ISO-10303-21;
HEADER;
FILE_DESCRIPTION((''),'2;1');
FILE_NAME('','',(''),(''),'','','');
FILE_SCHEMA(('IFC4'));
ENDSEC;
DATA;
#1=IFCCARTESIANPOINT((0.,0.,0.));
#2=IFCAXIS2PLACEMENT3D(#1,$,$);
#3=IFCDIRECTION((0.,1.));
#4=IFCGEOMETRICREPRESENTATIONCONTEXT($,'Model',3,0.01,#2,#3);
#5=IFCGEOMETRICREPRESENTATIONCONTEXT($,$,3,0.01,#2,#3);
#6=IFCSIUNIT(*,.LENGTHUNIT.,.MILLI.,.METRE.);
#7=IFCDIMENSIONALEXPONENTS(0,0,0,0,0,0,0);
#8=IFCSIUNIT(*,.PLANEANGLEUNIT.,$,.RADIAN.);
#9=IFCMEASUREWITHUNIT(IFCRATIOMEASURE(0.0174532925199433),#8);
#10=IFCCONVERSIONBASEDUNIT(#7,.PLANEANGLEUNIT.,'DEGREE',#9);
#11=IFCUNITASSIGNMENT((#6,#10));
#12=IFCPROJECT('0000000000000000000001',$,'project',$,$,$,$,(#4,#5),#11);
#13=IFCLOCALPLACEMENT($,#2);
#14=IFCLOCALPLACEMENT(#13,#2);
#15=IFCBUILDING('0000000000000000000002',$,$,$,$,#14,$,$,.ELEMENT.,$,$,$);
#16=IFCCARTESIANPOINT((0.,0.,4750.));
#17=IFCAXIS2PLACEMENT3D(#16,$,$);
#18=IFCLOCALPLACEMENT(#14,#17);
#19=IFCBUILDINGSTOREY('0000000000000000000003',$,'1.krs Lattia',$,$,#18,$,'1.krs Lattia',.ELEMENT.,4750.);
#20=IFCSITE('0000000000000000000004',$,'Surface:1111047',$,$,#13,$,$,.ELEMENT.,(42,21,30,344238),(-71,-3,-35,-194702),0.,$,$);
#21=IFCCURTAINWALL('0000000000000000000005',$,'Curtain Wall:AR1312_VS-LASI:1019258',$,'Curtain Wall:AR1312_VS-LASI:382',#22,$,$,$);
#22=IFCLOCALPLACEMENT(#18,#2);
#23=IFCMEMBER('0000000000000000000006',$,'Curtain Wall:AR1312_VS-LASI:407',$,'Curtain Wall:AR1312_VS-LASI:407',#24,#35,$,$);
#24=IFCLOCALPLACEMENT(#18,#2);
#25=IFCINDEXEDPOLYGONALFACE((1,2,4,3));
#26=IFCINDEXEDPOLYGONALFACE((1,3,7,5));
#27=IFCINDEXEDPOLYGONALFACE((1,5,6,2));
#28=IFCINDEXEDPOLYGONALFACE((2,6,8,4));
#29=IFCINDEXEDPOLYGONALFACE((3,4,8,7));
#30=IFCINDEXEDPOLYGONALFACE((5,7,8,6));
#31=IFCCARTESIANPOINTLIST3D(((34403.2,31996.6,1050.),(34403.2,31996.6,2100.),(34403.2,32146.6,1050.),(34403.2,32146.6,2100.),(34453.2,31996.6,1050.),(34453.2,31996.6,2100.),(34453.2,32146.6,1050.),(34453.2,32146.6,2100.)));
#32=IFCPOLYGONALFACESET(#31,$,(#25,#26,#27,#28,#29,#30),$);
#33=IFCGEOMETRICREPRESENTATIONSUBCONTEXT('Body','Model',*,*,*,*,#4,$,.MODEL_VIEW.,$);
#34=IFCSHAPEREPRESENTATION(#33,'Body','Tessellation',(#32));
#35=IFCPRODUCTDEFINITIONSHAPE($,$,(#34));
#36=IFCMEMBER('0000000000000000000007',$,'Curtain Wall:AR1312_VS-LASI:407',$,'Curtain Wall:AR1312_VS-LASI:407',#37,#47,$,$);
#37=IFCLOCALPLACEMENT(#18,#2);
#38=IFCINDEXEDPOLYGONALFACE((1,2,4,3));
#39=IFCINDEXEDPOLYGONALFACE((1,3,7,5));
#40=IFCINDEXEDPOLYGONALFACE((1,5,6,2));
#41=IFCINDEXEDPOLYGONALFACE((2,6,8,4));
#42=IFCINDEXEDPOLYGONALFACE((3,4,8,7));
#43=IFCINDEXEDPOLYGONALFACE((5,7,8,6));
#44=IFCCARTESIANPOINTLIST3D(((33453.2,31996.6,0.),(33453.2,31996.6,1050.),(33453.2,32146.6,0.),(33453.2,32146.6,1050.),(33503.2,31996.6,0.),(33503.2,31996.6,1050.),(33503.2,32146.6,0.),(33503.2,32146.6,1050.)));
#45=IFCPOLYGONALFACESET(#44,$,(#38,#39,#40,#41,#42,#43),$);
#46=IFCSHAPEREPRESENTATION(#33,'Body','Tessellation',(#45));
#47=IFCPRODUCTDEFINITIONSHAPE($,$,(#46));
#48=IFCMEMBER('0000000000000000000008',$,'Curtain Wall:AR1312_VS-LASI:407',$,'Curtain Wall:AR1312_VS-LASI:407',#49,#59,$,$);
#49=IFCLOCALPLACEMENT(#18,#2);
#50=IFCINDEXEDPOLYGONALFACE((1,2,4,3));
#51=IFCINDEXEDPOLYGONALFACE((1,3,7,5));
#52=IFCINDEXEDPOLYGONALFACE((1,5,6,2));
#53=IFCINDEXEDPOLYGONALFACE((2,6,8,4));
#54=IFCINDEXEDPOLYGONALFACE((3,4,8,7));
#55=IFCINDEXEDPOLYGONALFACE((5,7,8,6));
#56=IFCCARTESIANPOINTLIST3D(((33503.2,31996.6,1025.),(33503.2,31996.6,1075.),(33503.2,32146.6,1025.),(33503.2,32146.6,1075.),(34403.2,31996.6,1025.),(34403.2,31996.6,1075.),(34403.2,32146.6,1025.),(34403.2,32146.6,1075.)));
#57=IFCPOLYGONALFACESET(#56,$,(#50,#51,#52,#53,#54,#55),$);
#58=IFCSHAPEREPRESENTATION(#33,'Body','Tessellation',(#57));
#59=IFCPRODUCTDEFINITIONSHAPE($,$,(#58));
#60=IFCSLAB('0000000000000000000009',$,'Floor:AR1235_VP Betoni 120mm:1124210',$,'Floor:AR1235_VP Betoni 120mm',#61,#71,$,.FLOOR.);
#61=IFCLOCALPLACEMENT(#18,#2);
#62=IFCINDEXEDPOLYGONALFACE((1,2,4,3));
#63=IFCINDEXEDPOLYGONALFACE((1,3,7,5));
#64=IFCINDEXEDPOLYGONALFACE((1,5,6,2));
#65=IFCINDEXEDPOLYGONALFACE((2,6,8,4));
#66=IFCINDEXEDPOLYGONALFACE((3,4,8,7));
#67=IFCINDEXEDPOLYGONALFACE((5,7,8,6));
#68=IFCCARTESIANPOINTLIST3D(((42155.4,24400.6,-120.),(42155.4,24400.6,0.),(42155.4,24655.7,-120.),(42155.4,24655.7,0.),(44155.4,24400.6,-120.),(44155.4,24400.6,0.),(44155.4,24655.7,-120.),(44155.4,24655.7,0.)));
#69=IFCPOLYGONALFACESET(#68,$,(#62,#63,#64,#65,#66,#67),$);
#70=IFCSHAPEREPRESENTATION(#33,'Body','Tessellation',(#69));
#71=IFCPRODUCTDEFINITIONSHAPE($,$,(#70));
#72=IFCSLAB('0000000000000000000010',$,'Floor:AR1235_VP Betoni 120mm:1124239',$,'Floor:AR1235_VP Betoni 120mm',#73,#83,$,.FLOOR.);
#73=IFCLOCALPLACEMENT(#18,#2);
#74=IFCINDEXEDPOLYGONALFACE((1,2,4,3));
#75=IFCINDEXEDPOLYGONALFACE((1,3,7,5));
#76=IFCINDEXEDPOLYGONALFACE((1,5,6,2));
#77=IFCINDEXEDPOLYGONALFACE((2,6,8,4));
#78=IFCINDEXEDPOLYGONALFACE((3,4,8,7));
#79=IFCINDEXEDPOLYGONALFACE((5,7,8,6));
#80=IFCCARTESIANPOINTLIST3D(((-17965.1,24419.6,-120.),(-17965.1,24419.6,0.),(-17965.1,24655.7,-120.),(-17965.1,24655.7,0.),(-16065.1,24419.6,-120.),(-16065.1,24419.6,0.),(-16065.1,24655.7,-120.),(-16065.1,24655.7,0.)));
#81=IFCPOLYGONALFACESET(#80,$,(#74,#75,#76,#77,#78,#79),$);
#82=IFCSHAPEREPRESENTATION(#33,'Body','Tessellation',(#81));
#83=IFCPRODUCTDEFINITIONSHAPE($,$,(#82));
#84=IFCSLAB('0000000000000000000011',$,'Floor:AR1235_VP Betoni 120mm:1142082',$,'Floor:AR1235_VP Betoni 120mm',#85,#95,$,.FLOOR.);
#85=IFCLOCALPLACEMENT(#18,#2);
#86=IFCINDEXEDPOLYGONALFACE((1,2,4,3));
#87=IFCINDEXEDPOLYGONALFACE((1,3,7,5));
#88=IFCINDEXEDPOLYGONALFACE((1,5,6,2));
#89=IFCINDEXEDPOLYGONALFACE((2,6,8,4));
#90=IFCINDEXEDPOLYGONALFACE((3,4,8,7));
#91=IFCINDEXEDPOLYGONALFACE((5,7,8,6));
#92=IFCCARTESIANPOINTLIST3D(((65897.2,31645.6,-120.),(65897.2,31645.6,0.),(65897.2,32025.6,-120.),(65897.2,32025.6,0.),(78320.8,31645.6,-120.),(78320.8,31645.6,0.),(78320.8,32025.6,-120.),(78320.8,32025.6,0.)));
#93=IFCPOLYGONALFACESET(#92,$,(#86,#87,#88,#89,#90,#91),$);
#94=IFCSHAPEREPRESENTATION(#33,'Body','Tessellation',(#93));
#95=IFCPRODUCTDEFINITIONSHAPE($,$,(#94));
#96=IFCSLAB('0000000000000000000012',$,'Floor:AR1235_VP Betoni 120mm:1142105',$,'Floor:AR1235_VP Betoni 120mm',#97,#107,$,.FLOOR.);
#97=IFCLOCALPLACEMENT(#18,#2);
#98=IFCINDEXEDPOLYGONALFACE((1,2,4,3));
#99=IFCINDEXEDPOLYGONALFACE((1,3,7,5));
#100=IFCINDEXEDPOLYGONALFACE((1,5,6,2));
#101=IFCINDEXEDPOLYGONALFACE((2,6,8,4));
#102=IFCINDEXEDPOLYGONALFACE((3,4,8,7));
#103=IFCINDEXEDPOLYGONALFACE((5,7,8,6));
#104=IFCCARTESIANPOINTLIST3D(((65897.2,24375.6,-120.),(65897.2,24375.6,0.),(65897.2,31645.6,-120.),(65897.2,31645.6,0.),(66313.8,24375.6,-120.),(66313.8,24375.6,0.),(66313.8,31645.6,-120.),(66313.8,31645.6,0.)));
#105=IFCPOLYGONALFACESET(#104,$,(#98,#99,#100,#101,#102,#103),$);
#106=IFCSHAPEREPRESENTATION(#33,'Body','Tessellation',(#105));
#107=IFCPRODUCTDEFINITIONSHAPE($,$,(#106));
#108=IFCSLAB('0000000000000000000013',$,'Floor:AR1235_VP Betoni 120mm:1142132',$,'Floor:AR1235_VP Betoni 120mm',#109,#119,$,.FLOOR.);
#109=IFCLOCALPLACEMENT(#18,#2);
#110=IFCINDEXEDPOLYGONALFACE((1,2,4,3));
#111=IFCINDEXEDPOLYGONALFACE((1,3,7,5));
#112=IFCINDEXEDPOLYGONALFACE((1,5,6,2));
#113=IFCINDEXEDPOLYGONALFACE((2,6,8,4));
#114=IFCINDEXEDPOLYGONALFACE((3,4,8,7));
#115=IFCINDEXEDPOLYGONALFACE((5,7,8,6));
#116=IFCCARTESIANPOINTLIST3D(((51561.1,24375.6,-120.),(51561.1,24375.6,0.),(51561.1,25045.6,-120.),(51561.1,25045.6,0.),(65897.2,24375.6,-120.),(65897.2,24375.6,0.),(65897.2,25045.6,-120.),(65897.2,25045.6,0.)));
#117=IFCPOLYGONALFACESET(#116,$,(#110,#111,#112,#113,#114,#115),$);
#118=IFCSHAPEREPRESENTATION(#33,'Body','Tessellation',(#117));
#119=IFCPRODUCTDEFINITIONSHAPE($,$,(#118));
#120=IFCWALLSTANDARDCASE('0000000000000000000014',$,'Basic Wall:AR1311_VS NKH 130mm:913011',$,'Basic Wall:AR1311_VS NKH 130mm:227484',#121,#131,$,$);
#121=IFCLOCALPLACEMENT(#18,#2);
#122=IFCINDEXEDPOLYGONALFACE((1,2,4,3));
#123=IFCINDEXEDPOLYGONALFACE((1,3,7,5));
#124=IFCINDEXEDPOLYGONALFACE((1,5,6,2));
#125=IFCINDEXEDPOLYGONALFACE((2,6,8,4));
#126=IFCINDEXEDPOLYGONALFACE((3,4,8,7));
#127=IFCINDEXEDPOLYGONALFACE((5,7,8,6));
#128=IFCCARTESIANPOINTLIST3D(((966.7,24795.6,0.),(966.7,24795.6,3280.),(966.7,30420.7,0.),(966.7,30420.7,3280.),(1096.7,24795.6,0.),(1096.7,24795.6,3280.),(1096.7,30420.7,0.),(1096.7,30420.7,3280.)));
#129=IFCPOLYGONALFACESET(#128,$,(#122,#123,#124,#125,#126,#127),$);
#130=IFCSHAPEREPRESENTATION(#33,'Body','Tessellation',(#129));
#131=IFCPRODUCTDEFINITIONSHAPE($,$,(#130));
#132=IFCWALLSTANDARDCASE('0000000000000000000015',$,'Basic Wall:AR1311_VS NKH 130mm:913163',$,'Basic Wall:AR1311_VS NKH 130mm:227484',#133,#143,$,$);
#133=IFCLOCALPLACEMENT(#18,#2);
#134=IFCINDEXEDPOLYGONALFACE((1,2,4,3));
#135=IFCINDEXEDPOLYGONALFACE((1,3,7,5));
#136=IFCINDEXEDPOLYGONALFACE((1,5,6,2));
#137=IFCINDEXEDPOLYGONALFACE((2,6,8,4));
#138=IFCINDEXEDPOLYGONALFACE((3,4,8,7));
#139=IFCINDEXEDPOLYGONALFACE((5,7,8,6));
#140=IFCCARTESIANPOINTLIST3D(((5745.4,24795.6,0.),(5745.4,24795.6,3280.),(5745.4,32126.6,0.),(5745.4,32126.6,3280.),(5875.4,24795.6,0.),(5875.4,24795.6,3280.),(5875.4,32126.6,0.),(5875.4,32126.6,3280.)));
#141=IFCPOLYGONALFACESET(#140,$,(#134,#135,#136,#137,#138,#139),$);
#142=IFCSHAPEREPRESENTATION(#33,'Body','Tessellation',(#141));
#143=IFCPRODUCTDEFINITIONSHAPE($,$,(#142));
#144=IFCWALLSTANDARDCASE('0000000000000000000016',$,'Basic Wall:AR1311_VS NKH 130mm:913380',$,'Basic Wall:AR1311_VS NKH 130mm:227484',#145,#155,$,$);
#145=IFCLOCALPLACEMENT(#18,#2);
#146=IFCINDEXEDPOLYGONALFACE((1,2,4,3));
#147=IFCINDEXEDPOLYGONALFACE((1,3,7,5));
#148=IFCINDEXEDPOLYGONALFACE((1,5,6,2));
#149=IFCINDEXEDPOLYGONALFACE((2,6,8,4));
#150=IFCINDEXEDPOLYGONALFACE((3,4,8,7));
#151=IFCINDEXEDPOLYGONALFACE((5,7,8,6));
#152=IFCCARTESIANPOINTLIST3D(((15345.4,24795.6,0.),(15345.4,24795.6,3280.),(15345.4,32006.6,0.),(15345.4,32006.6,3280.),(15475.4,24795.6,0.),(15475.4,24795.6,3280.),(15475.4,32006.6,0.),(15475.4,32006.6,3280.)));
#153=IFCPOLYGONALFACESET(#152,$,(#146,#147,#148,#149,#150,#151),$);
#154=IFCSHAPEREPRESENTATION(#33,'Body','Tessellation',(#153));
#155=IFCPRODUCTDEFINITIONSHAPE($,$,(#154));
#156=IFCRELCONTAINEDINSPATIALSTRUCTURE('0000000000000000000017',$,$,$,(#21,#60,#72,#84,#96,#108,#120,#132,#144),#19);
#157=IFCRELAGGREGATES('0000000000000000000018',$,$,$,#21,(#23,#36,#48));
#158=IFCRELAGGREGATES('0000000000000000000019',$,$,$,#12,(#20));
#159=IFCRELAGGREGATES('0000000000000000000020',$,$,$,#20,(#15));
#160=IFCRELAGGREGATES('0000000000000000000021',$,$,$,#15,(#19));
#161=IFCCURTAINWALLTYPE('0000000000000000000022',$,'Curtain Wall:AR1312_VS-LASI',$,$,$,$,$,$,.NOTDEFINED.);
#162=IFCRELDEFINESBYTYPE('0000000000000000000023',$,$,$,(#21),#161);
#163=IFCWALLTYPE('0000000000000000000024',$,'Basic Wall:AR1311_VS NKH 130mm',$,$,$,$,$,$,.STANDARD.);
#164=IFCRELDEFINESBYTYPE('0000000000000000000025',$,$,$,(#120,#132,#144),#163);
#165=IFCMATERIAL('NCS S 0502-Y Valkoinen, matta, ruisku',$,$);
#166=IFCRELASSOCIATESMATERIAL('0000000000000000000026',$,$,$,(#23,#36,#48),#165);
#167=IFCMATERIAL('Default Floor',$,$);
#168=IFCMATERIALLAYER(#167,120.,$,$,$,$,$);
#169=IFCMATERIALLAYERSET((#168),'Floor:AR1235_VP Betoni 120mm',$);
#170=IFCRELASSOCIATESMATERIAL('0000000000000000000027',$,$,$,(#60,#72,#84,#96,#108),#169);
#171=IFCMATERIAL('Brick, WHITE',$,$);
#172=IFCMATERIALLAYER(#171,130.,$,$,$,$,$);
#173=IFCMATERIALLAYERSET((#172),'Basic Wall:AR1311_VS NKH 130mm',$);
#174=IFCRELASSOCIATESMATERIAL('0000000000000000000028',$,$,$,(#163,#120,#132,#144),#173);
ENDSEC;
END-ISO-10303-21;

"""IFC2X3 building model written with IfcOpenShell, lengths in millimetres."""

from ifc_helpers import new_model, entity, si_unit, converted_unit, direction, frame, frame_2d, origin, origin_2d_with_axis, place, context, subcontext, project, spatial, polyline, rectangle, extrude, clip, bounded_halfspace, material, layer, layer_set, layer_usage, type_object, element, aggregate, save


model = new_model("IFC2X3")

# Units and contexts
model_context = context("Model", 3, precision=0.01, world=origin(), true_north=direction((0.0, 1.0)))
context_of_model = context(None, 3, precision=0.01, world=origin(), true_north=direction((0.0, 1.0)))
body_context = subcontext(model_context, "Body", "Model", "MODEL_VIEW")
ifc_project = project(units=[si_unit("LENGTHUNIT", "METRE", prefix="MILLI"), converted_unit("PLANEANGLEUNIT", "DEGREE", entity("IfcRatioMeasure", 0.0174532925199433), si_unit("PLANEANGLEUNIT", "RADIAN"), dimensions=[0, 0, 0, 0, 0, 0, 0])], contexts=[model_context, context_of_model])

# Site, building, storey
site_placement = place(None, origin())
site = spatial("IfcSite", under=ifc_project, at=site_placement, Name="Surface:1111047", CompositionType="ELEMENT", RefLatitude=(42, 21, 30, 344238), RefLongitude=(-71, -3, -35, -194702), RefElevation=0.0)
building_placement = place(site_placement, origin())
building = spatial("IfcBuilding", under=site, at=building_placement, CompositionType="ELEMENT")
storey_placement = place(building_placement, frame((0.0, 0.0, 4750.0)))
storey = spatial("IfcBuildingStorey", under=building, at=storey_placement, Name="1.krs Lattia", LongName="1.krs Lattia", CompositionType="ELEMENT", Elevation=4750.0)

# Curtain wall, members
curtain_wall_type = type_object("IfcCurtainWallType", Name="Curtain Wall:AR1312_VS-LASI", PredefinedType="NOTDEFINED")
curtain_wall_1_placement = place(storey_placement, frame((0.0, 0.0, -4750.0)))
curtain_wall_1 = element("IfcCurtainWall", 1, at=curtain_wall_1_placement, inside=storey, type_object=curtain_wall_type, Name="Curtain Wall:AR1312_VS-LASI:1019258", ObjectType="Curtain Wall:AR1312_VS-LASI:382")
ifc_material_1 = material(Name="NCS S 0502-Y Valkoinen, matta, ruisku")
member_1_placement = place(curtain_wall_1_placement, frame((0.0, 0.0, 4750.0)))
member_1 = element("IfcMember", 2, at=member_1_placement, material=ifc_material_1, Name="Curtain Wall:AR1312_VS-LASI:407", ObjectType="Curtain Wall:AR1312_VS-LASI:407", context=body_context, shape_type="SweptSolid", body=[
    extrude(rectangle(XDim=50.0, YDim=150.0, at=frame_2d((0.0, 0.0), x_axis=(1.0, 0.0))), frame((34428.2, 32071.6, 1050.0), z_axis=(0.0, 0.0, 1.0), x_axis=(-1.0, 0.0, 0.0)), (0.0, 0.0, 1.0), 1050.0),
])
member_2_placement = place(curtain_wall_1_placement, frame((0.0, 0.0, 4750.0)))
member_2 = element("IfcMember", 3, at=member_2_placement, material=ifc_material_1, Name="Curtain Wall:AR1312_VS-LASI:407", ObjectType="Curtain Wall:AR1312_VS-LASI:407", context=body_context, shape_type="SweptSolid", body=[
    extrude(rectangle(XDim=50.0, YDim=150.0, at=frame_2d((0.0, 0.0), x_axis=(1.0, 0.0))), frame((33478.2, 32071.6, 1050.0), z_axis=(0.0, 0.0, -1.0), x_axis=(-1.0, 0.0, 0.0)), (0.0, 0.0, 1.0), 1050.0),
])
member_3_placement = place(curtain_wall_1_placement, frame((0.0, 0.0, 4750.0)))
member_3 = element("IfcMember", 4, at=member_3_placement, material=ifc_material_1, Name="Curtain Wall:AR1312_VS-LASI:407", ObjectType="Curtain Wall:AR1312_VS-LASI:407", context=body_context, shape_type="SweptSolid", body=[
    extrude(rectangle(XDim=50.0, YDim=150.0, at=frame_2d((0.0, 0.0), x_axis=(1.0, 0.0))), frame((34403.2, 32071.6, 1050.0), z_axis=(-1.0, 0.0, 0.0), x_axis=(0.0, 0.0, -1.0)), (0.0, 0.0, 1.0), 900.0),
])
aggregate(curtain_wall_1, [member_1, member_2, member_3])

# Slabs
ifc_material_2 = material(Name="Default Floor")
ifc_layer_1 = layer(ifc_material_2, 120.0)
ifc_layer_set_1 = layer_set([ifc_layer_1], Name="Floor:AR1235_VP Betoni 120mm")
ifc_layer_usage_1 = layer_usage(ifc_layer_set_1, "AXIS3", "POSITIVE", 0.0)
slab_1_placement = place(storey_placement, origin())
element("IfcSlab", 5, at=slab_1_placement, inside=storey, material=ifc_layer_usage_1, Name="Floor:AR1235_VP Betoni 120mm:1124210", ObjectType="Floor:AR1235_VP Betoni 120mm", PredefinedType="FLOOR", context=body_context, shape_type="SweptSolid", body=[
    extrude(rectangle(XDim=255.1, YDim=2000.0, at=frame_2d((0.0, 0.0), x_axis=(1.0, 0.0))), frame((43155.4, 24528.2, 0.0), z_axis=(0.0, 0.0, -1.0), x_axis=(0.0, 1.0, 0.0)), (0.0, 0.0, 1.0), 120.0),
])
ifc_layer_usage_2 = layer_usage(ifc_layer_set_1, "AXIS3", "POSITIVE", 0.0)
slab_2_placement = place(storey_placement, origin())
element("IfcSlab", 6, at=slab_2_placement, inside=storey, material=ifc_layer_usage_2, Name="Floor:AR1235_VP Betoni 120mm:1124239", ObjectType="Floor:AR1235_VP Betoni 120mm", PredefinedType="FLOOR", context=body_context, shape_type="SweptSolid", body=[
    extrude(rectangle(XDim=236.1, YDim=1900.0, at=frame_2d((0.0, 0.0), x_axis=(1.0, 0.0))), frame((-17015.1, 24537.7, 0.0), z_axis=(0.0, 0.0, -1.0), x_axis=(0.0, 1.0, 0.0)), (0.0, 0.0, 1.0), 120.0),
])
ifc_layer_usage_3 = layer_usage(ifc_layer_set_1, "AXIS3", "POSITIVE", 0.0)
slab_3_placement = place(storey_placement, origin())
element("IfcSlab", 7, at=slab_3_placement, inside=storey, material=ifc_layer_usage_3, Name="Floor:AR1235_VP Betoni 120mm:1142082", ObjectType="Floor:AR1235_VP Betoni 120mm", PredefinedType="FLOOR", context=body_context, shape_type="SweptSolid", body=[
    extrude(rectangle(XDim=380.0, YDim=12423.6, at=origin_2d_with_axis()), frame((72109.0, 31835.6, 0.0), z_axis=(0.0, 0.0, -1.0), x_axis=(0.0, 1.0, 0.0)), (0.0, 0.0, 1.0), 120.0),
])
ifc_layer_usage_4 = layer_usage(ifc_layer_set_1, "AXIS3", "POSITIVE", 0.0)
slab_4_placement = place(storey_placement, origin())
element("IfcSlab", 8, at=slab_4_placement, inside=storey, material=ifc_layer_usage_4, Name="Floor:AR1235_VP Betoni 120mm:1142105", ObjectType="Floor:AR1235_VP Betoni 120mm", PredefinedType="FLOOR", context=body_context, shape_type="SweptSolid", body=[
    extrude(rectangle(XDim=7270.0, YDim=416.6, at=frame_2d((0.0, 0.0), x_axis=(1.0, 0.0))), frame((66105.5, 28010.6, 0.0), z_axis=(0.0, 0.0, -1.0), x_axis=(0.0, 1.0, 0.0)), (0.0, 0.0, 1.0), 120.0),
])
ifc_layer_usage_5 = layer_usage(ifc_layer_set_1, "AXIS3", "POSITIVE", 0.0)
slab_5_placement = place(storey_placement, origin())
element("IfcSlab", 9, at=slab_5_placement, inside=storey, material=ifc_layer_usage_5, Name="Floor:AR1235_VP Betoni 120mm:1142132", ObjectType="Floor:AR1235_VP Betoni 120mm", PredefinedType="FLOOR", context=body_context, shape_type="SweptSolid", body=[
    extrude(rectangle(XDim=670.0, YDim=14336.1, at=frame_2d((0.0, 0.0), x_axis=(1.0, 0.0))), frame((58729.1, 24710.6, 0.0), z_axis=(0.0, 0.0, -1.0), x_axis=(0.0, 1.0, 0.0)), (0.0, 0.0, 1.0), 120.0),
])

# Walls
ifc_material_3 = material(Name="Brick, WHITE")
ifc_layer_2 = layer(ifc_material_3, 130.0)
ifc_layer_set_2 = layer_set([ifc_layer_2], Name="Basic Wall:AR1311_VS NKH 130mm")
ifc_layer_usage_6 = layer_usage(ifc_layer_set_2, "AXIS2", "NEGATIVE", 65.0)
wall_type = type_object("IfcWallType", Name="Basic Wall:AR1311_VS NKH 130mm", PredefinedType="STANDARD", material=ifc_layer_set_2)
wall_1_placement = place(storey_placement, frame((1031.7, 30420.7, 0.0), z_axis=(0.0, 0.0, 1.0), x_axis=(0.0, -1.0, 0.0)))
element("IfcWallStandardCase", 10, at=wall_1_placement, inside=storey, type_object=wall_type, material=ifc_layer_usage_6, Name="Basic Wall:AR1311_VS NKH 130mm:913011", ObjectType="Basic Wall:AR1311_VS NKH 130mm:227484", context=body_context, shape_type="Clipping", body=[
    clip(extrude(rectangle(XDim=5625.1, YDim=130.0, at=frame_2d((2812.6, 0.0), x_axis=(-1.0, 0.0))), origin(), (0.0, 0.0, 1.0), 3280.0), bounded_halfspace(frame((0.0, -65.0, 3280.0), z_axis=(0.0, 0.0, -1.0), x_axis=(-1.0, 0.0, 0.0)), True, frame((0.0, -65.0, 3280.0)), polyline([(0.0, 0.0), (5625.1, 0.0), (5625.1, 130.0), (0.0, 130.0), (0.0, 0.0)]))),
])
ifc_layer_usage_7 = layer_usage(ifc_layer_set_2, "AXIS2", "NEGATIVE", 65.0)
wall_2_placement = place(storey_placement, frame((5810.4, 24795.6, 0.0), z_axis=(0.0, 0.0, 1.0), x_axis=(0.0, 1.0, 0.0)))
element("IfcWallStandardCase", 11, at=wall_2_placement, inside=storey, type_object=wall_type, material=ifc_layer_usage_7, Name="Basic Wall:AR1311_VS NKH 130mm:913163", ObjectType="Basic Wall:AR1311_VS NKH 130mm:227484", context=body_context, shape_type="Clipping", body=[
    clip(extrude(rectangle(XDim=7331.0, YDim=130.0, at=frame_2d((3665.5, 0.0), x_axis=(-1.0, 0.0))), origin(), (0.0, 0.0, 1.0), 3280.0), bounded_halfspace(frame((0.0, -65.0, 3280.0), z_axis=(0.0, 0.0, -1.0), x_axis=(1.0, 0.0, 0.0)), True, frame((0.0, -65.0, 3280.0)), polyline([(0.0, 0.0), (7201.0, 0.0), (7331.0, 0.0), (7331.0, 130.0), (5755.1, 130.0), (5625.1, 130.0), (0.0, 130.0), (0.0, 0.0)]))),
])
ifc_layer_usage_8 = layer_usage(ifc_layer_set_2, "AXIS2", "NEGATIVE", 65.0)
wall_3_placement = place(storey_placement, frame((15410.4, 24795.6, 0.0), z_axis=(0.0, 0.0, 1.0), x_axis=(0.0, 1.0, 0.0)))
element("IfcWallStandardCase", 12, at=wall_3_placement, inside=storey, type_object=wall_type, material=ifc_layer_usage_8, Name="Basic Wall:AR1311_VS NKH 130mm:913380", ObjectType="Basic Wall:AR1311_VS NKH 130mm:227484", context=body_context, shape_type="Clipping", body=[
    clip(extrude(rectangle(XDim=7211.0, YDim=130.0, at=frame_2d((3605.5, 0.0), x_axis=(-1.0, 0.0))), origin(), (0.0, 0.0, 1.0), 3280.0), bounded_halfspace(frame((0.0, -65.0, 3280.0), z_axis=(0.0, 0.0, -1.0), x_axis=(1.0, 0.0, 0.0)), True, frame((0.0, -65.0, 3280.0)), polyline([(0.0, 0.0), (7211.0, 0.0), (7211.0, 130.0), (0.0, 130.0), (0.0, 0.0)]))),
])

save(model, "model.ifc")
